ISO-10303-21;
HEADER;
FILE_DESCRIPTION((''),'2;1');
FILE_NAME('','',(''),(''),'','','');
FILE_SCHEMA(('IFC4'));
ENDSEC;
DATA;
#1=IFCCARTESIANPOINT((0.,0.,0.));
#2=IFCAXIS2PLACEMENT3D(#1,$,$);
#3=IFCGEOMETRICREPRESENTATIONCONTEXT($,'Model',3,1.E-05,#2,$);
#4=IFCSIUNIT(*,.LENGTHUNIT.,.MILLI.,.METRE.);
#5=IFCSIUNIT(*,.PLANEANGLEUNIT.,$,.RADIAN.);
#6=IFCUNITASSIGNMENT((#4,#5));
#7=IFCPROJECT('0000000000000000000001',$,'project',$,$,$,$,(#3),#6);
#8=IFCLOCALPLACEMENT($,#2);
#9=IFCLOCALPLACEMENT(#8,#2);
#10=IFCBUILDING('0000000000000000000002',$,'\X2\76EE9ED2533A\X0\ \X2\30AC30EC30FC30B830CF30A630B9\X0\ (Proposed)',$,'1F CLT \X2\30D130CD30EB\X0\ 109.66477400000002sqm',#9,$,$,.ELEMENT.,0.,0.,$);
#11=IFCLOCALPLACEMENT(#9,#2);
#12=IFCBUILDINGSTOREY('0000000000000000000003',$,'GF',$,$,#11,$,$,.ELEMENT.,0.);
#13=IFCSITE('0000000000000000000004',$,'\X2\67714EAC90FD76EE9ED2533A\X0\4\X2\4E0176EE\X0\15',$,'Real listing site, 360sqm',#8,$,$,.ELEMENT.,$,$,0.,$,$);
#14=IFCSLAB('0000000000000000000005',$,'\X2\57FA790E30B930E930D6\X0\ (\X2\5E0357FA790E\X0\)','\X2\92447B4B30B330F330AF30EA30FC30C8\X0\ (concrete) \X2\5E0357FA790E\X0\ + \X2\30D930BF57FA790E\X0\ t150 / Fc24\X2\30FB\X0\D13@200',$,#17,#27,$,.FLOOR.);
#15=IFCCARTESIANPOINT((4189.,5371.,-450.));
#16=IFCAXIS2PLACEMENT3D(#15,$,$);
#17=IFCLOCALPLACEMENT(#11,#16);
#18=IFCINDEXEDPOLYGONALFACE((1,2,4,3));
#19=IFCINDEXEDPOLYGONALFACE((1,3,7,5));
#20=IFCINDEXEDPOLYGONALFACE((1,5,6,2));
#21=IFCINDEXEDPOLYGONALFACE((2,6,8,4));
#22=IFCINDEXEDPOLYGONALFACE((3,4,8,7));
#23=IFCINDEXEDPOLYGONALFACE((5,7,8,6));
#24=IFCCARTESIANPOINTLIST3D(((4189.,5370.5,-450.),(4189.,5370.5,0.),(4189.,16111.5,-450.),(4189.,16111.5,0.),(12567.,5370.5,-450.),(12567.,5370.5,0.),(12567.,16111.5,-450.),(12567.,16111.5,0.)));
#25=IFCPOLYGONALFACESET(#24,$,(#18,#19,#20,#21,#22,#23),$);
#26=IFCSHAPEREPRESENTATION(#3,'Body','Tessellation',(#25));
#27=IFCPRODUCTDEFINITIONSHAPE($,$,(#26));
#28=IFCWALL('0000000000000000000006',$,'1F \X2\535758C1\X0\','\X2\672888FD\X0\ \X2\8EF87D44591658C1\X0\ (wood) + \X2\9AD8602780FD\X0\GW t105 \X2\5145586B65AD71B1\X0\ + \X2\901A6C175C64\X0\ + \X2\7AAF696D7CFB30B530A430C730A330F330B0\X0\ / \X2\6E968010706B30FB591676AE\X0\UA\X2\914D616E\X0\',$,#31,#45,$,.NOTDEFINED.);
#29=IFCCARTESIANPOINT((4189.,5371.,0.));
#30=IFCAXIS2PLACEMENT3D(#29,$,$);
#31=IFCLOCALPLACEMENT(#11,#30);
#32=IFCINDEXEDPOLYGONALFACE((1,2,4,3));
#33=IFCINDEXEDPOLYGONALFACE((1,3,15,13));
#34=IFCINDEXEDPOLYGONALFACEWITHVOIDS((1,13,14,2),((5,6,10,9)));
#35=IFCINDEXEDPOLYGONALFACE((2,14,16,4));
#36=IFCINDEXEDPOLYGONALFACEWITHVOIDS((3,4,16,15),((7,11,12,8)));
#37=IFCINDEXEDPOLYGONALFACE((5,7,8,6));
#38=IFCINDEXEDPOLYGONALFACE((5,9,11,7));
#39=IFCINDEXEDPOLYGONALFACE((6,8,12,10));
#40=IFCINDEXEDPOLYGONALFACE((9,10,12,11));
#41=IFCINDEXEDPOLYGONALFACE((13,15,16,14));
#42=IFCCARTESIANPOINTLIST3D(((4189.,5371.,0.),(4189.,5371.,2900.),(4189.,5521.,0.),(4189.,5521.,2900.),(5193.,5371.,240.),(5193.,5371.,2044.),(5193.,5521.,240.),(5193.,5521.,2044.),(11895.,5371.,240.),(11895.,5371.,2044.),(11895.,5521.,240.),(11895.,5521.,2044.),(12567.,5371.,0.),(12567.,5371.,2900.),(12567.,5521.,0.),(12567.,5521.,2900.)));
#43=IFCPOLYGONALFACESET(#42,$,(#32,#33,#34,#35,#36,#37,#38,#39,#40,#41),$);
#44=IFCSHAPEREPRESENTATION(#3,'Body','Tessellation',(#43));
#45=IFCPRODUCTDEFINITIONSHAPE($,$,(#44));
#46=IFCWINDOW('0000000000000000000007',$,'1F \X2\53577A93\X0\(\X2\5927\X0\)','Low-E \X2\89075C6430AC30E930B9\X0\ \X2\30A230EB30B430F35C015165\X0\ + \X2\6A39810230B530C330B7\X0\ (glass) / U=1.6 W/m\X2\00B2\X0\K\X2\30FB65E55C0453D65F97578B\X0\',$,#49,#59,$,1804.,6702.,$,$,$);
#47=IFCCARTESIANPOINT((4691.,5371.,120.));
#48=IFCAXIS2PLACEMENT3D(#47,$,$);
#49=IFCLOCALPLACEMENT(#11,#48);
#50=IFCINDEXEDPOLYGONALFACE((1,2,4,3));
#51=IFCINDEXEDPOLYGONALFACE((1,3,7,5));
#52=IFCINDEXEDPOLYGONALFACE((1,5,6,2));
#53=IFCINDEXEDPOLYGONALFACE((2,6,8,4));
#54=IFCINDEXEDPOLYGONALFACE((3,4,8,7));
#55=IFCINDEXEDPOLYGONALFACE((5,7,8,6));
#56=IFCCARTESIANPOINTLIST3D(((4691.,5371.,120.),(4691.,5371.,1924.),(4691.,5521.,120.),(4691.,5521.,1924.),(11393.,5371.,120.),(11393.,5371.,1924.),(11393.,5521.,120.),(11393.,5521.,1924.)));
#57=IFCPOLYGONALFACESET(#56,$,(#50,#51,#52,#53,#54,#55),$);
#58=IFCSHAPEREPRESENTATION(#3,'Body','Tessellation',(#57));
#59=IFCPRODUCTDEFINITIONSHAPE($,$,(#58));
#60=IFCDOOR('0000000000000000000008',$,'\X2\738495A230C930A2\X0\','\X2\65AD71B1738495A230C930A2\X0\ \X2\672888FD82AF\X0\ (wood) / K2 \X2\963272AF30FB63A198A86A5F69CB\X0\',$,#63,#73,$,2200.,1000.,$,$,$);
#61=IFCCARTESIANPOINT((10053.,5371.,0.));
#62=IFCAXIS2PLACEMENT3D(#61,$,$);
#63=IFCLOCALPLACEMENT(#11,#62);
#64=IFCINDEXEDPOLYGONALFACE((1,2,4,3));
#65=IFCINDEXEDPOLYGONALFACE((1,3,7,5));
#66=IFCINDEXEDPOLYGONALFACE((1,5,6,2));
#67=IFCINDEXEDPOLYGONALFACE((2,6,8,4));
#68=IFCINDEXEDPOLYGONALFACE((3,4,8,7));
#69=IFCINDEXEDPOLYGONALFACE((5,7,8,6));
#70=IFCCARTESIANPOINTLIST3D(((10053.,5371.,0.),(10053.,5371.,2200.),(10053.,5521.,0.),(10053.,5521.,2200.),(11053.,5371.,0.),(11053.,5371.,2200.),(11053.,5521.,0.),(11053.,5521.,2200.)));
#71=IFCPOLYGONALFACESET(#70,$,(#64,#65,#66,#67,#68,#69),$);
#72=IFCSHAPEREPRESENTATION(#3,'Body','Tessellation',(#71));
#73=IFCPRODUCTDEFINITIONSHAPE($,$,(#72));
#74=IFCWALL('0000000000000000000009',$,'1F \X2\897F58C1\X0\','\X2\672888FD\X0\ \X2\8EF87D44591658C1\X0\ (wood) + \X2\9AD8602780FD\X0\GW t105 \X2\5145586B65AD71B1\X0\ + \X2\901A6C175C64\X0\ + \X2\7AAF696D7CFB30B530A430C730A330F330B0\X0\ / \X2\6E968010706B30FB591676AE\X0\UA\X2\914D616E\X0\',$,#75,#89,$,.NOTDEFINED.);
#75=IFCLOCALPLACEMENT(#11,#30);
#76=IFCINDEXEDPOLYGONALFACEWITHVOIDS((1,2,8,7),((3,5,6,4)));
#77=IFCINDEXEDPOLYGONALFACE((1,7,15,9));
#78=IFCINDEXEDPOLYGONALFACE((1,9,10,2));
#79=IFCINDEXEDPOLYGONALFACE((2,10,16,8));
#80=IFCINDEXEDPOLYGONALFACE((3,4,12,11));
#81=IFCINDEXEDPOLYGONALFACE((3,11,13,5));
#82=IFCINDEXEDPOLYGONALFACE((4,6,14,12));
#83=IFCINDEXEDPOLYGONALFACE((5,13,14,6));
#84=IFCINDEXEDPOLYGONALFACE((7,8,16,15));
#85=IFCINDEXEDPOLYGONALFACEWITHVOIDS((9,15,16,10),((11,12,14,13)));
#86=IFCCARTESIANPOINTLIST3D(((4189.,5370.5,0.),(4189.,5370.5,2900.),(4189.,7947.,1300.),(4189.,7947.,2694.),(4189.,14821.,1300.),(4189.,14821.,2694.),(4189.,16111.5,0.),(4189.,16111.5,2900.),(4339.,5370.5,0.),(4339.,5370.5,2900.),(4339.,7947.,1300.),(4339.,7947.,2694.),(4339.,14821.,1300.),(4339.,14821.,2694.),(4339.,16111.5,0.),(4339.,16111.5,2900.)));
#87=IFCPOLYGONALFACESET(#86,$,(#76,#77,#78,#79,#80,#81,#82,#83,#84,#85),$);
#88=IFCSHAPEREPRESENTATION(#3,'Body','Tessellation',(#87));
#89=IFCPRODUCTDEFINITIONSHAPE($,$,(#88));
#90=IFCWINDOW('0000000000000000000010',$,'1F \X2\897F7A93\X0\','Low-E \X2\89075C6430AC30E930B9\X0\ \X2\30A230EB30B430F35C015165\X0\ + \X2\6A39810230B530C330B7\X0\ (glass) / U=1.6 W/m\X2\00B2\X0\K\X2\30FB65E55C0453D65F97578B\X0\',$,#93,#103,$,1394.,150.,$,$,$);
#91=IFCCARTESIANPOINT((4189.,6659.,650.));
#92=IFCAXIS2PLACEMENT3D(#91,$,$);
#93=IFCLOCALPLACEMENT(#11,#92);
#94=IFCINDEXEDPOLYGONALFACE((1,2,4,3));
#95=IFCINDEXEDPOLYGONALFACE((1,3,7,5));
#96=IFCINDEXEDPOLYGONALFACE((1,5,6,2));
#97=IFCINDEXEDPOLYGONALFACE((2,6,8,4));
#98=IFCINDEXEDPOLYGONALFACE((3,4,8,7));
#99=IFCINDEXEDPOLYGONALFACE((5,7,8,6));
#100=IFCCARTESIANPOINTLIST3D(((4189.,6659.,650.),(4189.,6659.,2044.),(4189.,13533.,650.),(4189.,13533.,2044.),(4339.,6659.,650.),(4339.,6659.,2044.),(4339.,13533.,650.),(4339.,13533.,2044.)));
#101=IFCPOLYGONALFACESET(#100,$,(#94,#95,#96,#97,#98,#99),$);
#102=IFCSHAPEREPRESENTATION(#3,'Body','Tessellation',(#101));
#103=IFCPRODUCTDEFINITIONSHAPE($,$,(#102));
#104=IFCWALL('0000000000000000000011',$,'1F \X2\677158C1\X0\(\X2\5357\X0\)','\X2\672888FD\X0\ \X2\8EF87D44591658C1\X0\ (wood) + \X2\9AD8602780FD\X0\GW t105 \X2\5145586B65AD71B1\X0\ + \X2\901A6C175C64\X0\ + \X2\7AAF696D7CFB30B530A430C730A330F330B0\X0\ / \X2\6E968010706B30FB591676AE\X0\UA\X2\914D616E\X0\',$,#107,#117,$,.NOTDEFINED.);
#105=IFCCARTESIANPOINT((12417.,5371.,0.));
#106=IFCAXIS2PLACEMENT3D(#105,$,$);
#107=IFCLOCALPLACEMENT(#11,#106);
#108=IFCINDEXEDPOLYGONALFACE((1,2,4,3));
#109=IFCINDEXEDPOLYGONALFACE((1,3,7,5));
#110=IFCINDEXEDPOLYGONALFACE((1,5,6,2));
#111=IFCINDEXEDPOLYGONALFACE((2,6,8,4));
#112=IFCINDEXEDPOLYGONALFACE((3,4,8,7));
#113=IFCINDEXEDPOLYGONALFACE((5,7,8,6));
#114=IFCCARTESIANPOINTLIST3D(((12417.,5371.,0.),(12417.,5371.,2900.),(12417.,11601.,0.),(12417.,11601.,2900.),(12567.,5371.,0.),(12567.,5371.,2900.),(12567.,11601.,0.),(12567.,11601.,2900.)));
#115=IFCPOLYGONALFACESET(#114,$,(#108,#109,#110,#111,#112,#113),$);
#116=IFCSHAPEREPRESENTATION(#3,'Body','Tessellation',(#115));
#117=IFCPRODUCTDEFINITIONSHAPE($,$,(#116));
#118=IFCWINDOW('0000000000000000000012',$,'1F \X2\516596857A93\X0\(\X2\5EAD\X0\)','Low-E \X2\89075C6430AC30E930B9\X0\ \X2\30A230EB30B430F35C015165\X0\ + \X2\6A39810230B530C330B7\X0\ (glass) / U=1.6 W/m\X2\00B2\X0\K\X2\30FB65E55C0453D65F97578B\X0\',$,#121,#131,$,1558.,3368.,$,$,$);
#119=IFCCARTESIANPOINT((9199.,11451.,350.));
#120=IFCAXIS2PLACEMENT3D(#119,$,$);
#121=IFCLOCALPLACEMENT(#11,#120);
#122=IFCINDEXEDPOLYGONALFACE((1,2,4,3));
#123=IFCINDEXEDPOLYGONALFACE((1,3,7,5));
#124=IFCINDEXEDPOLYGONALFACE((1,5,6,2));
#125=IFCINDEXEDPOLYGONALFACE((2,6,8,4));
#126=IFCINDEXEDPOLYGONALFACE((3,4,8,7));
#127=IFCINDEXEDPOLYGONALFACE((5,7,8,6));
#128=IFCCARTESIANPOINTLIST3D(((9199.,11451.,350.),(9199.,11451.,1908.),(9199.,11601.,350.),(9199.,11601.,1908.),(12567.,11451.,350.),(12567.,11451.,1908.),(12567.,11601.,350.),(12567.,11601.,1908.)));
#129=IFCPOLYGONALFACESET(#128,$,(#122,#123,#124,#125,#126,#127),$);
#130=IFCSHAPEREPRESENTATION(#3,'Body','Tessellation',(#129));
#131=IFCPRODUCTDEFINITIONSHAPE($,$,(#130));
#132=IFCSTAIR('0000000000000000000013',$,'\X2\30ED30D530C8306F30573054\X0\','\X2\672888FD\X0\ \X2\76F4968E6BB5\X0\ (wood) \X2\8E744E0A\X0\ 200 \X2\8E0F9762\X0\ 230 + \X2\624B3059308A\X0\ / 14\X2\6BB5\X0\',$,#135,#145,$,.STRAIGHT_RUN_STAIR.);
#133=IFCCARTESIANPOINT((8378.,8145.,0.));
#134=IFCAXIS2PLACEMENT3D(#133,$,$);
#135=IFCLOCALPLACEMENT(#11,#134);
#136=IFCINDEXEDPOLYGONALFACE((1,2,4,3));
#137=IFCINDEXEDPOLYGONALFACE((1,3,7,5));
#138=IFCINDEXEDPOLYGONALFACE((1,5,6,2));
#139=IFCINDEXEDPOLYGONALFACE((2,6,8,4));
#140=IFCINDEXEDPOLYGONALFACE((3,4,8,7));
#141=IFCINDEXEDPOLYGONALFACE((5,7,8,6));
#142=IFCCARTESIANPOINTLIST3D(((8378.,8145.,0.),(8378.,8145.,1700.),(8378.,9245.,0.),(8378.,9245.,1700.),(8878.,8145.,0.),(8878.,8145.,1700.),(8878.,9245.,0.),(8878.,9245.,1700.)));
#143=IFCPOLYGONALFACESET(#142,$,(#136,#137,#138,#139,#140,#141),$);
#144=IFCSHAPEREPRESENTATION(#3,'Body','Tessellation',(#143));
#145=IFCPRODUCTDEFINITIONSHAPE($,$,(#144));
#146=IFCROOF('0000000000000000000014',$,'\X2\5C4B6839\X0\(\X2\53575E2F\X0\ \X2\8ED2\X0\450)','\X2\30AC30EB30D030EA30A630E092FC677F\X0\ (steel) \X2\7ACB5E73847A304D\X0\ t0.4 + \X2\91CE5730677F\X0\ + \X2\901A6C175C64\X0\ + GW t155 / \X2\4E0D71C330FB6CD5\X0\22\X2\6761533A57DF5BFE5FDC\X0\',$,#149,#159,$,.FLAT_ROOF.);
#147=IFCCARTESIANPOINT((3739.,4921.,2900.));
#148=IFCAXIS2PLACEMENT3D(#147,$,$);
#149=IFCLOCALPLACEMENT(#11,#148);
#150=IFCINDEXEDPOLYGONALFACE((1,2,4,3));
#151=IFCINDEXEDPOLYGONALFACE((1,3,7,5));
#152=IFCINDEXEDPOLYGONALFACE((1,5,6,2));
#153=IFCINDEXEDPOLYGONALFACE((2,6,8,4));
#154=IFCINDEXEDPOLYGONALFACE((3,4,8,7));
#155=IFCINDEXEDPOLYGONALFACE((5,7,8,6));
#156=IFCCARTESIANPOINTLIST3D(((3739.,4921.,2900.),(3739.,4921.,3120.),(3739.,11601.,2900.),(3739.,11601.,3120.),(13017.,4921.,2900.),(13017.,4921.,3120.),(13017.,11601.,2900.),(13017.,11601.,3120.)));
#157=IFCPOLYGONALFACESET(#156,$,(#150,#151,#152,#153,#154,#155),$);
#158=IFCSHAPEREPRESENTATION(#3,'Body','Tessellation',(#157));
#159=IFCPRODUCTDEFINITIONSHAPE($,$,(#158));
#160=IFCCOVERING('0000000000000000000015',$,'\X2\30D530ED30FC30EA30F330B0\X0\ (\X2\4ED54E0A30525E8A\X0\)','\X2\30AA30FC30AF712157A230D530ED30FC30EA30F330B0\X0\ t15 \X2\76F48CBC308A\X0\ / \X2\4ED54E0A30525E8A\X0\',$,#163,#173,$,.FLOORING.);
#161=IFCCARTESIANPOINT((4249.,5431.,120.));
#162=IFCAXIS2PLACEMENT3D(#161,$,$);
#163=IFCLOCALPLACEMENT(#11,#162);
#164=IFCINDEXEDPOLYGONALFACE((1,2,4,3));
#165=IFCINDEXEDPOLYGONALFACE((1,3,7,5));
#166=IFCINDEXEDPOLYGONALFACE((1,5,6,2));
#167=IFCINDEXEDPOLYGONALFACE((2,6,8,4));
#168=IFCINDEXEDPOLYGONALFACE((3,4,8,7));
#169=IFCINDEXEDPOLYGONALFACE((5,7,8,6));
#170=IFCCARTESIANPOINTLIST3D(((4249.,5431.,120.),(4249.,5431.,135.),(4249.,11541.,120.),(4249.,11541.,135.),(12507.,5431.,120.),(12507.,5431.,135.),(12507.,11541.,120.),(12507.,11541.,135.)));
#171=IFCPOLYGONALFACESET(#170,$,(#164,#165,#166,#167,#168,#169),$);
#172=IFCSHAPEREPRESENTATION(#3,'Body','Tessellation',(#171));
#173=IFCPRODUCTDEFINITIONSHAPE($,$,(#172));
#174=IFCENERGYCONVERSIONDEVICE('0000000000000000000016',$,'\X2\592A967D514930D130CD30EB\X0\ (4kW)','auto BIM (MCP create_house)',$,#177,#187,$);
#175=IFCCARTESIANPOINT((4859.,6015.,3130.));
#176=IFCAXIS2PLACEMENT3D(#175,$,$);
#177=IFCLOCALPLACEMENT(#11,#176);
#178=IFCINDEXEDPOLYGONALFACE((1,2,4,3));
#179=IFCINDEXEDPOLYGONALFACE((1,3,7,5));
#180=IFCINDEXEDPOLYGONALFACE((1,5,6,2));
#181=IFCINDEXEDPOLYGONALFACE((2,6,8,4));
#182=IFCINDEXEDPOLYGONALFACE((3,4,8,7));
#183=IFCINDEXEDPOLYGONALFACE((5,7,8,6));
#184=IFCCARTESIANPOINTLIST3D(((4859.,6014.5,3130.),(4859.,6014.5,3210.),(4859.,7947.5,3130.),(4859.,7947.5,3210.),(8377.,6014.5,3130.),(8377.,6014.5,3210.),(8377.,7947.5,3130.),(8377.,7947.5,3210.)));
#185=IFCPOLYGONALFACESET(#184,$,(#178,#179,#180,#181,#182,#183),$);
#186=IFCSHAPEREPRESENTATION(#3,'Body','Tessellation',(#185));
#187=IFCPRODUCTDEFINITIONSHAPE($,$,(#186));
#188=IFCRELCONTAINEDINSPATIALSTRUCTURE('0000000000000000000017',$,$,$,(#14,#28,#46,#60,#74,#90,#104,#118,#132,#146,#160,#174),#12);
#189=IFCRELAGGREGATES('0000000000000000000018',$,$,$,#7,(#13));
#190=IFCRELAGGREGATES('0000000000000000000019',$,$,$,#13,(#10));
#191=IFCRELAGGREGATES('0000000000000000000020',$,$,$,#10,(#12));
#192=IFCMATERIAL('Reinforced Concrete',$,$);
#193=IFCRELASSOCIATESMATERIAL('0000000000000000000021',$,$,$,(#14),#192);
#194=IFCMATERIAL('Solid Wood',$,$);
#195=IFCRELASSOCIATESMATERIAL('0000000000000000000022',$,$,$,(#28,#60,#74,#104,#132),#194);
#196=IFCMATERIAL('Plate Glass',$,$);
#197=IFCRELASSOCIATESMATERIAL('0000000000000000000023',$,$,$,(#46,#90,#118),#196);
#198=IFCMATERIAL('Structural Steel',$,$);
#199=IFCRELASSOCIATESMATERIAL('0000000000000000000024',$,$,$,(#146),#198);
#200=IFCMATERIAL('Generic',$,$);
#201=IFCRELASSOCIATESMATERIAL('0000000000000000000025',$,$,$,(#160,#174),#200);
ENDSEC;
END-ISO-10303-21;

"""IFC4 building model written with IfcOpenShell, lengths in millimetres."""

from ifc_helpers import new_model, si_unit, frame, frame_2d, origin, place, context, project, spatial, rectangle, extrude, material, element, fill, save


model = new_model("IFC4")

# Units and contexts
model_context = context("Model", 3, precision=1e-05, world=origin())
ifc_project = project(units=[si_unit("LENGTHUNIT", "METRE", prefix="MILLI"), si_unit("PLANEANGLEUNIT", "RADIAN")], contexts=[model_context])

# Site, building, storey
site_placement = place(None, origin())
site = spatial("IfcSite", under=ifc_project, at=site_placement, Name="東京都目黒区4丁目15", ObjectType="Real listing site, 360sqm", CompositionType="ELEMENT", RefElevation=0.0)
building_placement = place(site_placement, origin())
building = spatial("IfcBuilding", under=site, at=building_placement, Name="目黒区 ガレージハウス (Proposed)", ObjectType="1F CLT パネル 109.66477400000002sqm", CompositionType="ELEMENT", ElevationOfRefHeight=0.0, ElevationOfTerrain=0.0)
storey_placement = place(building_placement, origin())
storey = spatial("IfcBuildingStorey", under=building, at=storey_placement, Name="GF", CompositionType="ELEMENT", Elevation=0.0)

# Slab
ifc_material_1 = material(Name="Reinforced Concrete")
slab_1_placement = place(storey_placement, frame((4189.0, 5371.0, -450.0)))
element("IfcSlab", 1, at=slab_1_placement, inside=storey, material=ifc_material_1, Name="基礎スラブ (布基礎)", Description="鉄筋コンクリート (concrete) 布基礎 + ベタ基礎 t150 / Fc24・D13@200", PredefinedType="FLOOR", context=model_context, shape_type="SweptSolid", body=[
    extrude(rectangle(XDim=8378.0, YDim=10741.0, at=frame_2d((4189.0, 5370.0))), frame((4189.0, 5371.0, -450.0)), (0.0, 0.0, 1.0), 450.0),
])
ifc_material_2 = material(Name="Solid Wood")

# Wall, openings, window, door
wall_1_placement = place(storey_placement, frame((4189.0, 5371.0, 0.0)))
wall_1 = element("IfcWall", 2, at=wall_1_placement, inside=storey, material=ifc_material_2, Name="1F 南壁", Description="木製 軸組外壁 (wood) + 高性能GW t105 充填断熱 + 通気層 + 窯業系サイディング / 準耐火・外皮UA配慮", PredefinedType="NOTDEFINED", context=model_context, shape_type="SweptSolid", body=[
    extrude(rectangle(XDim=8378.0, YDim=150.0, at=frame_2d((4189.0, 75.0))), frame((4189.0, 5371.0, 0.0)), (0.0, 0.0, 1.0), 2900.0),
])
opening_1_placement = place(storey_placement, frame((4691.0, 5371.0, 120.0)))
opening_1 = element("IfcOpeningElement", 3, at=opening_1_placement, cuts=wall_1, PredefinedType="NOTDEFINED", context=model_context, shape_type="SweptSolid", body=[
    extrude(rectangle(XDim=6702.0, YDim=150.0, at=frame_2d((3351.0, 75.0))), frame((4691.0, 5371.0, 120.0)), (0.0, 0.0, 1.0), 1804.0),
])
opening_2_placement = place(storey_placement, frame((10053.0, 5371.0, 0.0)))
opening_2 = element("IfcOpeningElement", 4, at=opening_2_placement, cuts=wall_1, PredefinedType="NOTDEFINED", context=model_context, shape_type="SweptSolid", body=[
    extrude(rectangle(XDim=1000.0, YDim=150.0, at=frame_2d((500.0, 75.0))), frame((10053.0, 5371.0, 0.0)), (0.0, 0.0, 1.0), 2200.0),
])
ifc_material_3 = material(Name="Plate Glass")
window_1_placement = place(storey_placement, frame((4691.0, 5371.0, 120.0)))
window_1 = element("IfcWindow", 5, at=window_1_placement, inside=storey, material=ifc_material_3, Name="1F 南窓(大)", Description="Low-E 複層ガラス アルゴン封入 + 樹脂サッシ (glass) / U=1.6 W/m²K・日射取得型", OverallHeight=1804.0, OverallWidth=6702.0, context=model_context, shape_type="SweptSolid", body=[
    extrude(rectangle(XDim=6702.0, YDim=150.0, at=frame_2d((3351.0, 75.0))), frame((4691.0, 5371.0, 120.0)), (0.0, 0.0, 1.0), 1804.0),
])
fill(opening_1, window_1)
door_1_placement = place(storey_placement, frame((10053.0, 5371.0, 0.0)))
door_1 = element("IfcDoor", 6, at=door_1_placement, inside=storey, material=ifc_material_2, Name="玄関ドア", Description="断熱玄関ドア 木製芯 (wood) / K2 防犯・採風機構", OverallHeight=2200.0, OverallWidth=1000.0, context=model_context, shape_type="SweptSolid", body=[
    extrude(rectangle(XDim=1000.0, YDim=150.0, at=frame_2d((500.0, 75.0))), frame((10053.0, 5371.0, 0.0)), (0.0, 0.0, 1.0), 2200.0),
])
fill(opening_2, door_1)

# Walls, openings, windows
wall_2_placement = place(storey_placement, frame((4189.0, 5371.0, 0.0)))
wall_2 = element("IfcWall", 7, at=wall_2_placement, inside=storey, material=ifc_material_2, Name="1F 西壁", Description="木製 軸組外壁 (wood) + 高性能GW t105 充填断熱 + 通気層 + 窯業系サイディング / 準耐火・外皮UA配慮", PredefinedType="NOTDEFINED", context=model_context, shape_type="SweptSolid", body=[
    extrude(rectangle(XDim=150.0, YDim=10741.0, at=frame_2d((75.0, 5370.0))), frame((4189.0, 5371.0, 0.0)), (0.0, 0.0, 1.0), 2900.0),
])
opening_3_placement = place(storey_placement, frame((4189.0, 6659.0, 650.0)))
opening_3 = element("IfcOpeningElement", 8, at=opening_3_placement, cuts=wall_2, PredefinedType="NOTDEFINED", context=model_context, shape_type="SweptSolid", body=[
    extrude(rectangle(XDim=150.0, YDim=6874.0, at=frame_2d((75.0, 3437.0))), frame((4189.0, 6659.0, 650.0)), (0.0, 0.0, 1.0), 1394.0),
])
window_2_placement = place(storey_placement, frame((4189.0, 6659.0, 650.0)))
window_2 = element("IfcWindow", 9, at=window_2_placement, inside=storey, material=ifc_material_3, Name="1F 西窓", Description="Low-E 複層ガラス アルゴン封入 + 樹脂サッシ (glass) / U=1.6 W/m²K・日射取得型", OverallHeight=1394.0, OverallWidth=150.0, context=model_context, shape_type="SweptSolid", body=[
    extrude(rectangle(XDim=150.0, YDim=6874.0, at=frame_2d((75.0, 3437.0))), frame((4189.0, 6659.0, 650.0)), (0.0, 0.0, 1.0), 1394.0),
])
fill(opening_3, window_2)
wall_3_placement = place(storey_placement, frame((12417.0, 5371.0, 0.0)))
wall_3 = element("IfcWall", 10, at=wall_3_placement, inside=storey, material=ifc_material_2, Name="1F 東壁(南)", Description="木製 軸組外壁 (wood) + 高性能GW t105 充填断熱 + 通気層 + 窯業系サイディング / 準耐火・外皮UA配慮", PredefinedType="NOTDEFINED", context=model_context, shape_type="SweptSolid", body=[
    extrude(rectangle(XDim=150.0, YDim=6230.0, at=frame_2d((75.0, 3115.0))), frame((12417.0, 5371.0, 0.0)), (0.0, 0.0, 1.0), 2900.0),
])
opening_4_placement = place(storey_placement, frame((9199.0, 11451.0, 350.0)))
opening_4 = element("IfcOpeningElement", 11, at=opening_4_placement, cuts=wall_3, PredefinedType="NOTDEFINED", context=model_context, shape_type="SweptSolid", body=[
    extrude(rectangle(XDim=3368.0, YDim=150.0, at=frame_2d((1684.0, 75.0))), frame((9199.0, 11451.0, 350.0)), (0.0, 0.0, 1.0), 1558.0),
])
window_3_placement = place(storey_placement, frame((9199.0, 11451.0, 350.0)))
window_3 = element("IfcWindow", 12, at=window_3_placement, inside=storey, material=ifc_material_3, Name="1F 入隅窓(庭)", Description="Low-E 複層ガラス アルゴン封入 + 樹脂サッシ (glass) / U=1.6 W/m²K・日射取得型", OverallHeight=1558.0, OverallWidth=3368.0, context=model_context, shape_type="SweptSolid", body=[
    extrude(rectangle(XDim=3368.0, YDim=150.0, at=frame_2d((1684.0, 75.0))), frame((9199.0, 11451.0, 350.0)), (0.0, 0.0, 1.0), 1558.0),
])
fill(opening_4, window_3)

# Stair
stair_placement = place(storey_placement, frame((8378.0, 8145.0, 0.0)))
element("IfcStair", 13, at=stair_placement, inside=storey, material=ifc_material_2, Name="ロフトはしご", Description="木製 直階段 (wood) 蹴上 200 踏面 230 + 手すり / 14段", PredefinedType="STRAIGHT_RUN_STAIR", context=model_context, shape_type="SweptSolid", body=[
    extrude(rectangle(XDim=500.0, YDim=1100.0, at=frame_2d((250.0, 550.0))), frame((8378.0, 8145.0, 0.0)), (0.0, 0.0, 1.0), 1700.0),
])

# Roof
ifc_material_4 = material(Name="Structural Steel")
roof_placement = place(storey_placement, frame((3739.0, 4921.0, 2900.0)))
element("IfcRoof", 14, at=roof_placement, inside=storey, material=ifc_material_4, Name="屋根(南帯 軒450)", Description="ガルバリウム鋼板 (steel) 立平葺き t0.4 + 野地板 + 通気層 + GW t155 / 不燃・法22条区域対応", PredefinedType="FLAT_ROOF", context=model_context, shape_type="SweptSolid", body=[
    extrude(rectangle(XDim=9278.0, YDim=6680.0, at=frame_2d((4639.0, 3340.0))), frame((3739.0, 4921.0, 2900.0)), (0.0, 0.0, 1.0), 220.0),
])

# Covering
ifc_material_5 = material(Name="Generic")
covering_placement = place(storey_placement, frame((4249.0, 5431.0, 120.0)))
element("IfcCovering", 15, at=covering_placement, inside=storey, material=ifc_material_5, Name="フローリング (仕上げ床)", Description="オーク無垢フローリング t15 直貼り / 仕上げ床", PredefinedType="FLOORING", context=model_context, shape_type="SweptSolid", body=[
    extrude(rectangle(XDim=8258.0, YDim=6110.0, at=frame_2d((4129.0, 3055.0))), frame((4249.0, 5431.0, 120.0)), (0.0, 0.0, 1.0), 15.0),
])

# Energy conversion device
energy_conversion_device_placement = place(storey_placement, frame((4859.0, 6015.0, 3130.0)))
element("IfcEnergyConversionDevice", 16, at=energy_conversion_device_placement, inside=storey, material=ifc_material_5, Name="太陽光パネル (4kW)", Description="auto BIM (MCP create_house)", context=model_context, shape_type="SweptSolid", body=[
    extrude(rectangle(XDim=3518.0, YDim=1933.0, at=frame_2d((1759.0, 966.0))), frame((4859.0, 6015.0, 3130.0)), (0.0, 0.0, 1.0), 80.0),
])

save(model, "model.ifc")
